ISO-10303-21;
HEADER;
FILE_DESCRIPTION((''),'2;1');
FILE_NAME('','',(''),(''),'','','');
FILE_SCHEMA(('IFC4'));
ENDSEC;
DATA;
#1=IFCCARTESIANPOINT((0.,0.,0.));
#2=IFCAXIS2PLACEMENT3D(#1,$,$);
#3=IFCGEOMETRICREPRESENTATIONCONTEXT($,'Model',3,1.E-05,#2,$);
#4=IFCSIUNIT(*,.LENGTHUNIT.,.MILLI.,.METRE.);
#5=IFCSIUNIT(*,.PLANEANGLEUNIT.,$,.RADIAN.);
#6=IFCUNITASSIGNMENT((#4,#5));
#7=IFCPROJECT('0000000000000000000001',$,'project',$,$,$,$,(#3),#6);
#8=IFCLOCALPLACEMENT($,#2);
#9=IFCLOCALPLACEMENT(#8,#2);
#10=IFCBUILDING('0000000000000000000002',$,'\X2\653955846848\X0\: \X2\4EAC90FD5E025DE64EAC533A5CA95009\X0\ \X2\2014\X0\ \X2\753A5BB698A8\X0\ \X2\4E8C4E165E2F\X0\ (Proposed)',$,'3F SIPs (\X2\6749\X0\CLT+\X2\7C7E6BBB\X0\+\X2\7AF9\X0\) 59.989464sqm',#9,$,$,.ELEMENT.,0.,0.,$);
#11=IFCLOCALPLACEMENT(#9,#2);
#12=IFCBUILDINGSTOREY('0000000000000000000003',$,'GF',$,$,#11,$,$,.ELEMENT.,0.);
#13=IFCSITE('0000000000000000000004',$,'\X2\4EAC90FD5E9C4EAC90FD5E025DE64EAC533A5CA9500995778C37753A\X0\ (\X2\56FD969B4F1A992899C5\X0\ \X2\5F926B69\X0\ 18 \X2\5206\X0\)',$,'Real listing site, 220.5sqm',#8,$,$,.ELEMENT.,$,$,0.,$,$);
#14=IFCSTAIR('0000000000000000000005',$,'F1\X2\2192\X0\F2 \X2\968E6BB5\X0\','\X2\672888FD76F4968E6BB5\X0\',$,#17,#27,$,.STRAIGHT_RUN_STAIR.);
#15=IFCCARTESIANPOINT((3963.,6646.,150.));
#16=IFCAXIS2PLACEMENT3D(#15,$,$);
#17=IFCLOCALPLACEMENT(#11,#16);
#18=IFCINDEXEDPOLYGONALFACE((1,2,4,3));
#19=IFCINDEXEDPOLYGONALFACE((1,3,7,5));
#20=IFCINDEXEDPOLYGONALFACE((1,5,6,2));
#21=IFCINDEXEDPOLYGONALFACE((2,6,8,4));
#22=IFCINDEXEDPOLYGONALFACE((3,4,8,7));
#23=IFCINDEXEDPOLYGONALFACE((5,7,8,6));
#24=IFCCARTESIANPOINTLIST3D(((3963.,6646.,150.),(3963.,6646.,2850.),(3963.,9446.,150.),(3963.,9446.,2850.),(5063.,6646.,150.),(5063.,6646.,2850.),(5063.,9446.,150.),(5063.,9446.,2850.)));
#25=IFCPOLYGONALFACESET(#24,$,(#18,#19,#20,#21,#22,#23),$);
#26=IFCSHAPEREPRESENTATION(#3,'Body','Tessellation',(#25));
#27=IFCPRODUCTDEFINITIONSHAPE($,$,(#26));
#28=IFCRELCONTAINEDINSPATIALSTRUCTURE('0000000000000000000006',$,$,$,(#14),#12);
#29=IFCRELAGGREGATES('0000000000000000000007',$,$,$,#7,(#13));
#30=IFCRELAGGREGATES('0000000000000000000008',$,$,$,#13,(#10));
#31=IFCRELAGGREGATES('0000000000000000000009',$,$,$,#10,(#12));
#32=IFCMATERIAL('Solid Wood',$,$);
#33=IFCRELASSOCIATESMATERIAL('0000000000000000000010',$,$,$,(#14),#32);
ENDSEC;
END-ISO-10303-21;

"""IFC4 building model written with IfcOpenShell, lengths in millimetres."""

from ifc_helpers import new_model, si_unit, frame, frame_2d, origin, place, context, project, spatial, rectangle, extrude, material, element, save


model = new_model("IFC4")

# Units and contexts
model_context = context("Model", 3, precision=1e-05, world=origin())
ifc_project = project(units=[si_unit("LENGTHUNIT", "METRE", prefix="MILLI"), si_unit("PLANEANGLEUNIT", "RADIAN")], contexts=[model_context])

# Site, building, storey
site_placement = place(None, origin())
site = spatial("IfcSite", under=ifc_project, at=site_placement, Name="京都府京都市左京区岩倉長谷町 (国際会館駅 徒歩 18 分)", ObjectType="Real listing site, 220.5sqm", CompositionType="ELEMENT", RefElevation=0.0)
building_placement = place(site_placement, origin())
building = spatial("IfcBuilding", under=site, at=building_placement, Name="改善案: 京都市左京区岩倉 — 町家風 二世帯 (Proposed)", ObjectType="3F SIPs (杉CLT+籾殻+竹) 59.989464sqm", CompositionType="ELEMENT", ElevationOfRefHeight=0.0, ElevationOfTerrain=0.0)
storey_placement = place(building_placement, origin())
storey = spatial("IfcBuildingStorey", under=building, at=storey_placement, Name="GF", CompositionType="ELEMENT", Elevation=0.0)

# Shared definitions
ifc_material_1 = material(Name="Solid Wood")

# Stair
stair_placement = place(storey_placement, frame((3963.0, 6646.0, 150.0)))
element("IfcStair", 1, at=stair_placement, inside=storey, material=ifc_material_1, Name="F1→F2 階段", Description="木製直階段", PredefinedType="STRAIGHT_RUN_STAIR", context=model_context, shape_type="SweptSolid", body=[
    extrude(rectangle(XDim=1100.0, YDim=2800.0, at=frame_2d((550.0, 1400.0))), frame((3963.0, 6646.0, 150.0)), (0.0, 0.0, 1.0), 2700.0),
])

save(model, "model.ifc")
